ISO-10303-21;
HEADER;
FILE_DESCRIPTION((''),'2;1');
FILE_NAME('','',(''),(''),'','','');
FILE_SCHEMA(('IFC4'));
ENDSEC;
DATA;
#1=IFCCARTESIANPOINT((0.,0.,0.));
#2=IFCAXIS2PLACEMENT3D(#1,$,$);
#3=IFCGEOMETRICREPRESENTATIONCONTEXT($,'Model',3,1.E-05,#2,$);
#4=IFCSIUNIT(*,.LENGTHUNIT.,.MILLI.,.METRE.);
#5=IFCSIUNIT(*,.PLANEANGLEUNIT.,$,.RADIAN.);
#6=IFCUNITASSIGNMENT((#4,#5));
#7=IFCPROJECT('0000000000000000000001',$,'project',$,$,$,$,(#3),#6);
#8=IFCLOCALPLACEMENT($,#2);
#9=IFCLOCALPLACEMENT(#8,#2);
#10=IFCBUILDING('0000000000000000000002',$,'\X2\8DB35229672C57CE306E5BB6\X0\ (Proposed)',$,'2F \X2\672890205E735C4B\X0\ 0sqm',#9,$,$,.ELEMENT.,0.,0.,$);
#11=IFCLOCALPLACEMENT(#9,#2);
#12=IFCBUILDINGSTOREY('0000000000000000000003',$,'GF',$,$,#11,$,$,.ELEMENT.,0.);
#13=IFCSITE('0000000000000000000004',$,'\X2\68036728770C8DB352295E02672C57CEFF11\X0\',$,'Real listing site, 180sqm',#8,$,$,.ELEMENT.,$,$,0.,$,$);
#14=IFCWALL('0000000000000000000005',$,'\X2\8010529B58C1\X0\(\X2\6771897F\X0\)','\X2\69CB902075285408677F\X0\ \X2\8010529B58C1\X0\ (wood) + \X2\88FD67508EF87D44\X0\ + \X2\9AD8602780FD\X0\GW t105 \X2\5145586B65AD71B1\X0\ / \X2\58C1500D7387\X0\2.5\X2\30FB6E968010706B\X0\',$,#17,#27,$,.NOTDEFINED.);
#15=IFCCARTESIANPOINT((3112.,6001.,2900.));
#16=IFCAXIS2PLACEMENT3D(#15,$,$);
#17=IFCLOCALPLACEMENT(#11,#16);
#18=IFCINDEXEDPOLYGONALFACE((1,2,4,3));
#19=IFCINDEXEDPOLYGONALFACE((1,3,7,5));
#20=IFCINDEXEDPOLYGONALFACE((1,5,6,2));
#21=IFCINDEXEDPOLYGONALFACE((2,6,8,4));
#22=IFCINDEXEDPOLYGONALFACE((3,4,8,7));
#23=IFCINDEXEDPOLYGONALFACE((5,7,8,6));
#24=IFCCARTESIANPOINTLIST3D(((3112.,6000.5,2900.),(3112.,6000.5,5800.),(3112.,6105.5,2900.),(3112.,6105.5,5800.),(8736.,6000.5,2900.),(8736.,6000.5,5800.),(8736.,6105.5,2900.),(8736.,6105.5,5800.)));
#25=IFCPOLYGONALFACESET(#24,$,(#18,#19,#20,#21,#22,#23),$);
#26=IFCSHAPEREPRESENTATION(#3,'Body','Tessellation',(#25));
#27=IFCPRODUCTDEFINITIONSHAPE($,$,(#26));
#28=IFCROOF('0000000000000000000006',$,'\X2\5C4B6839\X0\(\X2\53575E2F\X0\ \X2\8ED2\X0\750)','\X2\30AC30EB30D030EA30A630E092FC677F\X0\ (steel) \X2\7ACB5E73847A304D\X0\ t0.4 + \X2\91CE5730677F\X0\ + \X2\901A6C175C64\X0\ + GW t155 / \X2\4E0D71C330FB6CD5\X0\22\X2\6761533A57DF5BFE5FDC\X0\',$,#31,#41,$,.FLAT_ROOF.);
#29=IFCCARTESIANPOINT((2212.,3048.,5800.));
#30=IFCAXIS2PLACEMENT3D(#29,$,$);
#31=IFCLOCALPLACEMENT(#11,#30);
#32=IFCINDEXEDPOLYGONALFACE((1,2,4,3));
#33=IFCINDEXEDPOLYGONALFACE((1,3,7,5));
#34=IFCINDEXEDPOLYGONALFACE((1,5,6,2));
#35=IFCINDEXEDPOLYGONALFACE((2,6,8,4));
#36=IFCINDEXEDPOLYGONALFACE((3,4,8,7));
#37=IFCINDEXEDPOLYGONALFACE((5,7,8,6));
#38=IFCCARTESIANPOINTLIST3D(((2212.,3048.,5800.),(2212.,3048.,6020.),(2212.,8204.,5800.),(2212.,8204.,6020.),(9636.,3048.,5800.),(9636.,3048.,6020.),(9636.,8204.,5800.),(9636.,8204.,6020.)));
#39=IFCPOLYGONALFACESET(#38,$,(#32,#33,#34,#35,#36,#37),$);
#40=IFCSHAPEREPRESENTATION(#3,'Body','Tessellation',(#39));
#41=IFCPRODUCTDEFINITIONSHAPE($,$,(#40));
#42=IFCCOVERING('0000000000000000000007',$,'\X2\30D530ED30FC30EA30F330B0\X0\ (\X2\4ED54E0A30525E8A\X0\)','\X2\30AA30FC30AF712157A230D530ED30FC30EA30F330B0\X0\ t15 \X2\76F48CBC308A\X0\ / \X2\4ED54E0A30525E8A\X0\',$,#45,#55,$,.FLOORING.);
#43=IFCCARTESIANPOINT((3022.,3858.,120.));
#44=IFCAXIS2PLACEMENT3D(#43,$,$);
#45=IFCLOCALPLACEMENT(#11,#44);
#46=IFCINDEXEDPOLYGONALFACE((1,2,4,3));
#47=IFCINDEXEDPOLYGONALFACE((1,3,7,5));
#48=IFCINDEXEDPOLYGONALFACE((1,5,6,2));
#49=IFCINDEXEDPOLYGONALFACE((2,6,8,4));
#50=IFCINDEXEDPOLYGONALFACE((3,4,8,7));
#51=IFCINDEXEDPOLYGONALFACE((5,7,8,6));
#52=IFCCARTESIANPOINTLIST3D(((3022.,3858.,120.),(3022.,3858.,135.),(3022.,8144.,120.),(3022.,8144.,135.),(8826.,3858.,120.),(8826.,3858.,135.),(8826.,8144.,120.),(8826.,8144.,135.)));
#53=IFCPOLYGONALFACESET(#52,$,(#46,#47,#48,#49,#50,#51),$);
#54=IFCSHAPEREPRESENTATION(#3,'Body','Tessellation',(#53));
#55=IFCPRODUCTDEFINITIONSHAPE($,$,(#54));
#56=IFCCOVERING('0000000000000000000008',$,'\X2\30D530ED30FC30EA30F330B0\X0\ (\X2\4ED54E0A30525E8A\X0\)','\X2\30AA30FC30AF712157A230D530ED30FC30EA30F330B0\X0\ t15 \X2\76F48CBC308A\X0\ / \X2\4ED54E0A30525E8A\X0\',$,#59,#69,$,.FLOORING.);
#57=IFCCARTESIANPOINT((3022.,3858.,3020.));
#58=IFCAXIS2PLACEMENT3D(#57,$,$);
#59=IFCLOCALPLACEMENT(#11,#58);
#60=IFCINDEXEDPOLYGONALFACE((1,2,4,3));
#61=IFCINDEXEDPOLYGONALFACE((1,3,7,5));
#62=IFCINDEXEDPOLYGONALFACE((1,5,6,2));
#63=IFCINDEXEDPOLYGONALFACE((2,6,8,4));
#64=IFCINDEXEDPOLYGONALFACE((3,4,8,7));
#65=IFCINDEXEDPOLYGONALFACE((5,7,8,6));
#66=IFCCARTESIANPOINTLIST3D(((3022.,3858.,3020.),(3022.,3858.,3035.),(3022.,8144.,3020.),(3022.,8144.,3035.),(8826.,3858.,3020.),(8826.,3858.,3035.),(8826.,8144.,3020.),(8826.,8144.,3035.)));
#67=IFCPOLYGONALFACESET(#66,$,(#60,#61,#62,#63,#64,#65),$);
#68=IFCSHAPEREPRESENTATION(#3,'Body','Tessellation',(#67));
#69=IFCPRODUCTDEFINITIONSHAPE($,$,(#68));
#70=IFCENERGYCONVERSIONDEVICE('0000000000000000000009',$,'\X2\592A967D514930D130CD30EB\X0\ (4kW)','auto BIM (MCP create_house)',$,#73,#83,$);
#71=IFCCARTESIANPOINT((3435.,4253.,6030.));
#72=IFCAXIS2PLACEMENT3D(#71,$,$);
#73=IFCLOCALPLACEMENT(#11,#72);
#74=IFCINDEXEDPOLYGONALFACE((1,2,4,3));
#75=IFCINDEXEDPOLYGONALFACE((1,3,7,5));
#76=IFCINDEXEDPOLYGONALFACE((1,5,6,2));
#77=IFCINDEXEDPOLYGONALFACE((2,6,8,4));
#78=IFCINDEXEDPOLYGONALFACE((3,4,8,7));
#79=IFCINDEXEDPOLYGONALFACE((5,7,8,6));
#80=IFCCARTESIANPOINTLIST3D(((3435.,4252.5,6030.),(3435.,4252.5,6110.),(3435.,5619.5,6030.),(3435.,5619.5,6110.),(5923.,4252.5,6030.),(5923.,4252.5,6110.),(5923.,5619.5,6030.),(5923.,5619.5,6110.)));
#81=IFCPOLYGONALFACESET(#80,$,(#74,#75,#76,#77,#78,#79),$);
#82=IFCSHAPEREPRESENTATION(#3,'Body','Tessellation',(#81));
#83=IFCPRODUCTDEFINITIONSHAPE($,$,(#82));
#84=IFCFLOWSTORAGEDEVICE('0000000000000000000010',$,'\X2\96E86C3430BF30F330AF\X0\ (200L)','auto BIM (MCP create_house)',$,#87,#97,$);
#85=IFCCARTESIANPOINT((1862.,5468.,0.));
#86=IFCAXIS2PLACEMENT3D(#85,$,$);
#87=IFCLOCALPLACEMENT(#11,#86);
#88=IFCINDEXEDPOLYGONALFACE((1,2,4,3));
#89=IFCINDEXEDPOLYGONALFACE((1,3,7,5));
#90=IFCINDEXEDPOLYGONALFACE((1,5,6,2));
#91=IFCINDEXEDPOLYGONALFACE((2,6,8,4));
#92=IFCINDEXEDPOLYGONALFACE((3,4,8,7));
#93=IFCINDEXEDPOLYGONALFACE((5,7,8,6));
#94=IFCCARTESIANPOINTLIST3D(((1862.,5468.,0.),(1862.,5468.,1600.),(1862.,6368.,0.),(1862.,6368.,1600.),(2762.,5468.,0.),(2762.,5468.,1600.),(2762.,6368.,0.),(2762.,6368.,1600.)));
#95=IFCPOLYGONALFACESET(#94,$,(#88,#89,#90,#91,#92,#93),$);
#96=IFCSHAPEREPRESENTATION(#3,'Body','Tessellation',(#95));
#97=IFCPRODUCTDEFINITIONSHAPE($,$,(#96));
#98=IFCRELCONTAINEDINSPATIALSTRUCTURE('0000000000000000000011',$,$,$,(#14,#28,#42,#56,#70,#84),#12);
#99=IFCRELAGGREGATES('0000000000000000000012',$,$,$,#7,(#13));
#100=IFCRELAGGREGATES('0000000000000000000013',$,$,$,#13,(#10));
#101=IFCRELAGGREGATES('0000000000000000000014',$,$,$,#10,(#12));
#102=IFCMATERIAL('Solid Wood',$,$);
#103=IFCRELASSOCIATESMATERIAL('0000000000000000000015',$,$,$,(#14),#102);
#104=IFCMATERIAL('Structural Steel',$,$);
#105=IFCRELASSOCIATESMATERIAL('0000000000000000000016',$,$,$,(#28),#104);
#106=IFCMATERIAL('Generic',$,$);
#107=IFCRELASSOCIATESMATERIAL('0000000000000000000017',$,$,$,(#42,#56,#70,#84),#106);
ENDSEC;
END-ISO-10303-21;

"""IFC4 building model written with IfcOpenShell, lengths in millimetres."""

from ifc_helpers import new_model, si_unit, frame, frame_2d, origin, place, context, project, spatial, rectangle, extrude, material, element, save


model = new_model("IFC4")

# Units and contexts
model_context = context("Model", 3, precision=1e-05, world=origin())
ifc_project = project(units=[si_unit("LENGTHUNIT", "METRE", prefix="MILLI"), si_unit("PLANEANGLEUNIT", "RADIAN")], contexts=[model_context])

# Site, building, storey
site_placement = place(None, origin())
site = spatial("IfcSite", under=ifc_project, at=site_placement, Name="栃木県足利市本城１", ObjectType="Real listing site, 180sqm", CompositionType="ELEMENT", RefElevation=0.0)
building_placement = place(site_placement, origin())
building = spatial("IfcBuilding", under=site, at=building_placement, Name="足利本城の家 (Proposed)", ObjectType="2F 木造平屋 0sqm", CompositionType="ELEMENT", ElevationOfRefHeight=0.0, ElevationOfTerrain=0.0)
storey_placement = place(building_placement, origin())
storey = spatial("IfcBuildingStorey", under=building, at=storey_placement, Name="GF", CompositionType="ELEMENT", Elevation=0.0)

# Shared definitions
ifc_material_1 = material(Name="Solid Wood")

# Wall
wall_1_placement = place(storey_placement, frame((3112.0, 6001.0, 2900.0)))
element("IfcWall", 1, at=wall_1_placement, inside=storey, material=ifc_material_1, Name="耐力壁(東西)", Description="構造用合板 耐力壁 (wood) + 製材軸組 + 高性能GW t105 充填断熱 / 壁倍率2.5・準耐火", PredefinedType="NOTDEFINED", context=model_context, shape_type="SweptSolid", body=[
    extrude(rectangle(XDim=5624.0, YDim=105.0, at=frame_2d((2812.0, 52.0))), frame((3112.0, 6001.0, 2900.0)), (0.0, 0.0, 1.0), 2900.0),
])

# Roof
ifc_material_2 = material(Name="Structural Steel")
for number, where, name in (
    (2, (2212.0, 3048.0, 5800.0), "屋根(南帯 軒750)"),
):
    element("IfcRoof", number, at=place(storey_placement, frame(where)), inside=storey, material=ifc_material_2, Name=name, Description="ガルバリウム鋼板 (steel) 立平葺き t0.4 + 野地板 + 通気層 + GW t155 / 不燃・法22条区域対応", PredefinedType="FLAT_ROOF", context=model_context, shape_type="SweptSolid", body=[
        extrude(rectangle(XDim=7424.0, YDim=5156.0, at=frame_2d((3712.0, 2578.0))), frame((2212.0, 3048.0, 5800.0)), (0.0, 0.0, 1.0), 220.0),
    ])

# Coverings
ifc_material_3 = material(Name="Generic")
covering_1_placement = place(storey_placement, frame((3022.0, 3858.0, 120.0)))
element("IfcCovering", 3, at=covering_1_placement, inside=storey, material=ifc_material_3, Name="フローリング (仕上げ床)", Description="オーク無垢フローリング t15 直貼り / 仕上げ床", PredefinedType="FLOORING", context=model_context, shape_type="SweptSolid", body=[
    extrude(rectangle(XDim=5804.0, YDim=4286.0, at=frame_2d((2902.0, 2143.0))), frame((3022.0, 3858.0, 120.0)), (0.0, 0.0, 1.0), 15.0),
])
covering_2_placement = place(storey_placement, frame((3022.0, 3858.0, 3020.0)))
element("IfcCovering", 4, at=covering_2_placement, inside=storey, material=ifc_material_3, Name="フローリング (仕上げ床)", Description="オーク無垢フローリング t15 直貼り / 仕上げ床", PredefinedType="FLOORING", context=model_context, shape_type="SweptSolid", body=[
    extrude(rectangle(XDim=5804.0, YDim=4286.0, at=frame_2d((2902.0, 2143.0))), frame((3022.0, 3858.0, 3020.0)), (0.0, 0.0, 1.0), 15.0),
])

# Energy conversion device
energy_conversion_device_placement = place(storey_placement, frame((3435.0, 4253.0, 6030.0)))
element("IfcEnergyConversionDevice", 5, at=energy_conversion_device_placement, inside=storey, material=ifc_material_3, Name="太陽光パネル (4kW)", Description="auto BIM (MCP create_house)", context=model_context, shape_type="SweptSolid", body=[
    extrude(rectangle(XDim=2488.0, YDim=1367.0, at=frame_2d((1244.0, 683.0))), frame((3435.0, 4253.0, 6030.0)), (0.0, 0.0, 1.0), 80.0),
])

# Flow storage device
flow_storage_device_placement = place(storey_placement, frame((1862.0, 5468.0, 0.0)))
element("IfcFlowStorageDevice", 6, at=flow_storage_device_placement, inside=storey, material=ifc_material_3, Name="雨水タンク (200L)", Description="auto BIM (MCP create_house)", context=model_context, shape_type="SweptSolid", body=[
    extrude(rectangle(XDim=900.0, YDim=900.0, at=frame_2d((450.0, 450.0))), frame((1862.0, 5468.0, 0.0)), (0.0, 0.0, 1.0), 1600.0),
])

save(model, "model.ifc")
